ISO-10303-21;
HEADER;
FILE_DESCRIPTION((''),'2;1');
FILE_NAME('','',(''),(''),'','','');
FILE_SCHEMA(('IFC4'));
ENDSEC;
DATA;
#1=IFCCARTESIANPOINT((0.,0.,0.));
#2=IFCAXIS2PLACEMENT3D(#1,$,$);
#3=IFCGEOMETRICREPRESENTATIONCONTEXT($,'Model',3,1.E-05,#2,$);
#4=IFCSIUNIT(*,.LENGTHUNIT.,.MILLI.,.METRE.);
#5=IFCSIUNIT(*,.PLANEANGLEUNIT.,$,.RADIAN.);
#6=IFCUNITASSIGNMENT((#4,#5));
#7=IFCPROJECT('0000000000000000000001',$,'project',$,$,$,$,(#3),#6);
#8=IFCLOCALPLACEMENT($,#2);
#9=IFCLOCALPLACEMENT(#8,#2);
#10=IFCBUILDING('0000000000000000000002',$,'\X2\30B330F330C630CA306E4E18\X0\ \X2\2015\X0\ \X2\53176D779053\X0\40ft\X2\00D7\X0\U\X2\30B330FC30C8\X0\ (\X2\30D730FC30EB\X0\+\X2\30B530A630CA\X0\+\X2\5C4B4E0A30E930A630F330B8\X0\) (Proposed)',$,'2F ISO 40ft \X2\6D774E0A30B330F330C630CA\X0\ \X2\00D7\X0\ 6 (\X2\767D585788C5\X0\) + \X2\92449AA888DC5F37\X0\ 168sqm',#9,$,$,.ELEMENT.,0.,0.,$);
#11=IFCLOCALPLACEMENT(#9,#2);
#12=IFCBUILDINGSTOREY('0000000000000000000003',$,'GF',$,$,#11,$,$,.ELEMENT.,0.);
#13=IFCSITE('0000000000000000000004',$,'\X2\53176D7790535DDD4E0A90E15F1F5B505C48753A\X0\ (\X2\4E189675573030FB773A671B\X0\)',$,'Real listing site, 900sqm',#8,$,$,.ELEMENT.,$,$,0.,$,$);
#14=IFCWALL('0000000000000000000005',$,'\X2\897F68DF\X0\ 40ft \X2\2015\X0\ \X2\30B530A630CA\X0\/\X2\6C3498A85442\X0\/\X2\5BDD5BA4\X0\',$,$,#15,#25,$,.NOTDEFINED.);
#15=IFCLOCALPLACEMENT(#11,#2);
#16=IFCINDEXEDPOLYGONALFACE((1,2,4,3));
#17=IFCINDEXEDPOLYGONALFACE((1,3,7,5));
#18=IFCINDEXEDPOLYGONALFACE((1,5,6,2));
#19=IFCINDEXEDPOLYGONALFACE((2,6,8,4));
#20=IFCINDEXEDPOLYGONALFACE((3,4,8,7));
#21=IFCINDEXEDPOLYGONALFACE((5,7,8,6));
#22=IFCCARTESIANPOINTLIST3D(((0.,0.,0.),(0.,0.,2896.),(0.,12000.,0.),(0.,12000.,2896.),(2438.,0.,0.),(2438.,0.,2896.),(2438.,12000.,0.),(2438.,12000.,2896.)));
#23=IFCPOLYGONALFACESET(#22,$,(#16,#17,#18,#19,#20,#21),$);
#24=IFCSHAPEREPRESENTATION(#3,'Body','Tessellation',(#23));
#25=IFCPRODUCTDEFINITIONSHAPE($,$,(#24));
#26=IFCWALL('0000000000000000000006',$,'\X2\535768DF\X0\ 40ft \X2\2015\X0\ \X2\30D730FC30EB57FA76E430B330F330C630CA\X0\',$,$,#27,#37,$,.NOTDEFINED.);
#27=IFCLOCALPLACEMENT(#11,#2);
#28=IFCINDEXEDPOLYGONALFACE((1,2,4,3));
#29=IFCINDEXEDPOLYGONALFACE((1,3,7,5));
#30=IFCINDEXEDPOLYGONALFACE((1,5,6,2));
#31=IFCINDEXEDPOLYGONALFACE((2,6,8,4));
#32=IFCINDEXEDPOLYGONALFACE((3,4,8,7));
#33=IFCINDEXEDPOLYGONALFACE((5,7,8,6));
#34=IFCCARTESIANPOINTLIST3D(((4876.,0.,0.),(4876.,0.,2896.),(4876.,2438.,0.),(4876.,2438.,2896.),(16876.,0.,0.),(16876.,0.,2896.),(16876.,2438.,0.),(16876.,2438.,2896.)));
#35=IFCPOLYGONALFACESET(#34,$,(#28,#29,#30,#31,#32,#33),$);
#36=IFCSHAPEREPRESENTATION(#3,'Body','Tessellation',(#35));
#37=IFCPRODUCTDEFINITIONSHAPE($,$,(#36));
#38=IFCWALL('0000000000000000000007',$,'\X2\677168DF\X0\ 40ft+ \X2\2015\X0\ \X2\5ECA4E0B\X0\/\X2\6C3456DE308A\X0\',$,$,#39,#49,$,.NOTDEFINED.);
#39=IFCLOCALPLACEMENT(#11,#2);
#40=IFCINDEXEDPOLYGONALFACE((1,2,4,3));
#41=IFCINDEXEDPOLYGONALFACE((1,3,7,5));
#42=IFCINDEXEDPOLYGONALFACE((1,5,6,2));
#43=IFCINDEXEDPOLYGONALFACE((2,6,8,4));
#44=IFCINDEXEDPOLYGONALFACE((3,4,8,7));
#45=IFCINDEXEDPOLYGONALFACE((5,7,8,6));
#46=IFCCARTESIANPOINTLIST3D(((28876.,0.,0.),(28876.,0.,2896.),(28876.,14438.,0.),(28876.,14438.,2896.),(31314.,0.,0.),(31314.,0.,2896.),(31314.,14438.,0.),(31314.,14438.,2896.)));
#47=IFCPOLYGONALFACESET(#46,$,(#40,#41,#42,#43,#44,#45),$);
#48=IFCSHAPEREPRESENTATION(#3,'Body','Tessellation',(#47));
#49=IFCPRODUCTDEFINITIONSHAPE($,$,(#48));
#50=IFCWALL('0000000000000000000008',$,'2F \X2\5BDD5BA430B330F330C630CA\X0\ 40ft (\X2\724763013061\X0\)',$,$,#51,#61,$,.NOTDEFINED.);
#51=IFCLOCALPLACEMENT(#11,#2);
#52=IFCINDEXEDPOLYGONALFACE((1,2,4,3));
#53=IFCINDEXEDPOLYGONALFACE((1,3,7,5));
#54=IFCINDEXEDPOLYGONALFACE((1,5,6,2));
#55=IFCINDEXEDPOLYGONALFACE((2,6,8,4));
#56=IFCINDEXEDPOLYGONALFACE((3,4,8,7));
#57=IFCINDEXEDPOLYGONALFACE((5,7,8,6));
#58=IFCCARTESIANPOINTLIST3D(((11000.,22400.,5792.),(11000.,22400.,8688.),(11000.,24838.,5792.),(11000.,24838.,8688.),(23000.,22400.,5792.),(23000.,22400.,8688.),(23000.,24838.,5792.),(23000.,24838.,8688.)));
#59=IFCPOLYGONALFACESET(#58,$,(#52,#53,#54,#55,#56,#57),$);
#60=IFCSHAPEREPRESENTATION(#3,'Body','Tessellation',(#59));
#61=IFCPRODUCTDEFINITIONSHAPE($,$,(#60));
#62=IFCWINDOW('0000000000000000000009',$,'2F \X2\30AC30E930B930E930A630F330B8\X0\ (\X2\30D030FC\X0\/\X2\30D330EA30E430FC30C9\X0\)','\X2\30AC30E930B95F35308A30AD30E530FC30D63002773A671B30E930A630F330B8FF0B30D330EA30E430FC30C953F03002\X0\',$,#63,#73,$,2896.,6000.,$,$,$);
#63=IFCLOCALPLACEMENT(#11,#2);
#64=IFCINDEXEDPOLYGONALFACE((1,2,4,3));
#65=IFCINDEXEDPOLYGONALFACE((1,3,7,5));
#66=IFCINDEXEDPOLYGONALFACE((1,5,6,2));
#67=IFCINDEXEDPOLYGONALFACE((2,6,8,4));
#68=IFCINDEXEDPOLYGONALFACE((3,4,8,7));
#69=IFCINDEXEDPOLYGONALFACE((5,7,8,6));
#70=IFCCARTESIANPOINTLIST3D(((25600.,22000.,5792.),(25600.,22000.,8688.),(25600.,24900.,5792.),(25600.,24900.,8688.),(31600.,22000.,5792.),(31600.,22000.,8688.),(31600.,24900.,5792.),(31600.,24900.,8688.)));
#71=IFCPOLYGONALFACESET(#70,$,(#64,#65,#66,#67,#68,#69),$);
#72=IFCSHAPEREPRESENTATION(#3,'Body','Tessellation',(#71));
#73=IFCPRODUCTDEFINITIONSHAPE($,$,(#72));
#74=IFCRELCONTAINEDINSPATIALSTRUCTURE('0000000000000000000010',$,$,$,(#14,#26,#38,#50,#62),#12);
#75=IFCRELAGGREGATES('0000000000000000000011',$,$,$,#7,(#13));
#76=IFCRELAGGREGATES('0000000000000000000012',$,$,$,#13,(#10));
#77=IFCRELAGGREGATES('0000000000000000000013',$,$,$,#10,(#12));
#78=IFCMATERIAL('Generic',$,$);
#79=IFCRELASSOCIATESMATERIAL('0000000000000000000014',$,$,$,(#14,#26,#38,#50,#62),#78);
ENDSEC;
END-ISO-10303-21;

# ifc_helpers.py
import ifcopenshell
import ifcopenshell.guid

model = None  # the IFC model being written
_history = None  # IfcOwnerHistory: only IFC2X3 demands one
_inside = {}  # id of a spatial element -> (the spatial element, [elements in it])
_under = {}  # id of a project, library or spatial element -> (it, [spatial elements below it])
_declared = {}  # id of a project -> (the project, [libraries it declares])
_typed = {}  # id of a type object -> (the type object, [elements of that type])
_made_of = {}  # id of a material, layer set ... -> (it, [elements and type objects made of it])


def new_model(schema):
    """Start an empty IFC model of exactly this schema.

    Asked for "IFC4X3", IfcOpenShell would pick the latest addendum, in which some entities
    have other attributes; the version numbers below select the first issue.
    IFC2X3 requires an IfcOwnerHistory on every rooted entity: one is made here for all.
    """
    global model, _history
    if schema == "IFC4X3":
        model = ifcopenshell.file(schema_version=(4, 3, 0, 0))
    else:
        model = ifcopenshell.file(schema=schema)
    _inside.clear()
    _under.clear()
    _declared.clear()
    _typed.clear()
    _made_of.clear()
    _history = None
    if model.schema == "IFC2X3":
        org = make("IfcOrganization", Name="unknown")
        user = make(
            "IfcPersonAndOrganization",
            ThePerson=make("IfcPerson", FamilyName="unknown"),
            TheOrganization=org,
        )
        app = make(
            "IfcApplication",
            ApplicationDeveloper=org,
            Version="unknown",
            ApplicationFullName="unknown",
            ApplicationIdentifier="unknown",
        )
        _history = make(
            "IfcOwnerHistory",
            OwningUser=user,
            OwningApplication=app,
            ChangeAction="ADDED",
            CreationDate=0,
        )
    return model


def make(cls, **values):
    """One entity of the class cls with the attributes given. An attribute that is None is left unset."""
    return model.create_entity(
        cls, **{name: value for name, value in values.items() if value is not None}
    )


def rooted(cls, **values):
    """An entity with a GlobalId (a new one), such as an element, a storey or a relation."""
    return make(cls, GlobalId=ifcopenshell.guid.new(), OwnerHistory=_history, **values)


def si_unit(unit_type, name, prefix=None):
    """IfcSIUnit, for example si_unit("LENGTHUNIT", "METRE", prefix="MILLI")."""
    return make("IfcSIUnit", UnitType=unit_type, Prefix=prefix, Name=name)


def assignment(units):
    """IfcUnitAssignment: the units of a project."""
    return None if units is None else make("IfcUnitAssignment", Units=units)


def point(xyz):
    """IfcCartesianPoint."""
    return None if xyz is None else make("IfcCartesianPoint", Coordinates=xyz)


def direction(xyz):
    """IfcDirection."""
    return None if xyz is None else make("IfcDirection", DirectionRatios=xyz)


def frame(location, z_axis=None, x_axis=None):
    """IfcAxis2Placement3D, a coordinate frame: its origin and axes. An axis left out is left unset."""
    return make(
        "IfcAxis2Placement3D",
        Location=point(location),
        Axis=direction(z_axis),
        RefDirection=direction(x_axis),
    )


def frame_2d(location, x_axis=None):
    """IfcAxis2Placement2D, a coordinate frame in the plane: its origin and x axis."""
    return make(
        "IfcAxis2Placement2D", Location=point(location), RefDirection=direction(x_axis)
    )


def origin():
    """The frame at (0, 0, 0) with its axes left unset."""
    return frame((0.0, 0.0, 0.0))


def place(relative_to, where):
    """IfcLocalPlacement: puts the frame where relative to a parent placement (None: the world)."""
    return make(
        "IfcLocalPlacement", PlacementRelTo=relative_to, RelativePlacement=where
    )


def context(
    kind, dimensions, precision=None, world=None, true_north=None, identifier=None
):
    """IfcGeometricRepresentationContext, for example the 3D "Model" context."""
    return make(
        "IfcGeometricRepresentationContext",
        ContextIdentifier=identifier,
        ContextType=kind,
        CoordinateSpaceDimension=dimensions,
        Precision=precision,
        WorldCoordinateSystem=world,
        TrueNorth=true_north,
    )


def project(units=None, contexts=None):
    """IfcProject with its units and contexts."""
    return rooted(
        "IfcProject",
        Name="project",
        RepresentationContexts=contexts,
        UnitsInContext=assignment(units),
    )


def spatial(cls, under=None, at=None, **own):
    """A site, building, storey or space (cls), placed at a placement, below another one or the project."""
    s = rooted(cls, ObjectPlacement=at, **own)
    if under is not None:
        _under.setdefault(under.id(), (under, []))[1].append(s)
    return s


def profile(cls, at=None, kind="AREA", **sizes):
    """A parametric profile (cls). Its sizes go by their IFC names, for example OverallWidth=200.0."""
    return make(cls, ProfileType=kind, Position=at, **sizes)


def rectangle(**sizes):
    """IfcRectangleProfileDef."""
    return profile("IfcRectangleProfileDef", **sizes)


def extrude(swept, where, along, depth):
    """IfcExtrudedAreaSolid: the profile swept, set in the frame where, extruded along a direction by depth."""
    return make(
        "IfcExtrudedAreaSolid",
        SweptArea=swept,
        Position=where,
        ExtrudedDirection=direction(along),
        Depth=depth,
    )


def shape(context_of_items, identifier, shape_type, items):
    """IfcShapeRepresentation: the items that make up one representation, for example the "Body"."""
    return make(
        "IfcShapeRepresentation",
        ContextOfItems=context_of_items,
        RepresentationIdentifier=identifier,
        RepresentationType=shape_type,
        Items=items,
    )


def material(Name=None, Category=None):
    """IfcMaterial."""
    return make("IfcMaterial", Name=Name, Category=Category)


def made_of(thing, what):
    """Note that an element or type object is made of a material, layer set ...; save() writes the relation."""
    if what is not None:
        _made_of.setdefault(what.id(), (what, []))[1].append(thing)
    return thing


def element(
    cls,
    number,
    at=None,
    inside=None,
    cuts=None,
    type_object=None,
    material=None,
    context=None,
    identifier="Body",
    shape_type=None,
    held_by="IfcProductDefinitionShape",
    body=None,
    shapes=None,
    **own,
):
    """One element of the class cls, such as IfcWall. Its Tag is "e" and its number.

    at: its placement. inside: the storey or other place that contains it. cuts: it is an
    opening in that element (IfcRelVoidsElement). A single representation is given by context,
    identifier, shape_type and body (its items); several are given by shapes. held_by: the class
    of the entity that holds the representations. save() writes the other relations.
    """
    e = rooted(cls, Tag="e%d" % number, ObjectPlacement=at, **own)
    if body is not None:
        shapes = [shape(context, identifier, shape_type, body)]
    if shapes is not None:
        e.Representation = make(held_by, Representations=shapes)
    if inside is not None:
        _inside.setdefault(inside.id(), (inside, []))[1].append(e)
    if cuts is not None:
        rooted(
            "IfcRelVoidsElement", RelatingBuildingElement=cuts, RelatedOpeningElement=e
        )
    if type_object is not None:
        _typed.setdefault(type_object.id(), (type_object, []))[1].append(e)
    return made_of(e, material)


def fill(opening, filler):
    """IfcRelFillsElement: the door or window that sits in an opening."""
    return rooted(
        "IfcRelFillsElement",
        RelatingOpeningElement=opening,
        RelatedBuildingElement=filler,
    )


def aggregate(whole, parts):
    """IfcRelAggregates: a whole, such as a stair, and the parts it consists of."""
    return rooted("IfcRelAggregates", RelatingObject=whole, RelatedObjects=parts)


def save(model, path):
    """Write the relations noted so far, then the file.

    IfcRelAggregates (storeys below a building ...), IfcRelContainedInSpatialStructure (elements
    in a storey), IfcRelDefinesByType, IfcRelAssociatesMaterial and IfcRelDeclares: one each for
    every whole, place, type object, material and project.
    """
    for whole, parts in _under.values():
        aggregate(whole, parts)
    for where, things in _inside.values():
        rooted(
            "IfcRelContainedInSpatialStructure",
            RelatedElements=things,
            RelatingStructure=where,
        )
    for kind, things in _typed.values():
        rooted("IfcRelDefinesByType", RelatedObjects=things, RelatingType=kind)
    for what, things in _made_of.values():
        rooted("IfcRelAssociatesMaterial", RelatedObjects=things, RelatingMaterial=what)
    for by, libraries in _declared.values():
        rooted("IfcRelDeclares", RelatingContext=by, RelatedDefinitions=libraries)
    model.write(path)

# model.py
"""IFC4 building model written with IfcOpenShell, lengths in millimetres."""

from ifc_helpers import new_model, si_unit, frame, frame_2d, origin, place, context, project, spatial, rectangle, extrude, material, element, fill, save


model = new_model("IFC4")

# Units and contexts
model_context = context("Model", 3, precision=1e-05, world=origin())
ifc_project = project(units=[si_unit("LENGTHUNIT", "METRE", prefix="MILLI"), si_unit("PLANEANGLEUNIT", "RADIAN")], contexts=[model_context])

# Site, building, storey
site_placement = place(None, origin())
site = spatial("IfcSite", under=ifc_project, at=site_placement, Name="北海道川上郡弟子屈町 (丘陵地・眺望)", ObjectType="Real listing site, 900sqm", CompositionType="ELEMENT", RefElevation=0.0)
building_placement = place(site_placement, origin())
building = spatial("IfcBuilding", under=site, at=building_placement, Name="コンテナの丘 ― 北海道40ft×Uコート (プール+サウナ+屋上ラウンジ) (Proposed)", ObjectType="2F ISO 40ft 海上コンテナ × 6 (白塗装) + 鉄骨補強 168sqm", CompositionType="ELEMENT", ElevationOfRefHeight=0.0, ElevationOfTerrain=0.0)
storey_placement = place(building_placement, origin())
storey = spatial("IfcBuildingStorey", under=building, at=storey_placement, Name="GF", CompositionType="ELEMENT", Elevation=0.0)

# Shared definitions
ifc_material = material(Name="Generic")

# Walls
wall_1_placement = place(storey_placement, origin())
element("IfcWall", 1, at=wall_1_placement, inside=storey, material=ifc_material, Name="西棟 40ft ― サウナ/水風呂/寝室", PredefinedType="NOTDEFINED", context=model_context, shape_type="SweptSolid", body=[
    extrude(rectangle(XDim=2438.0, YDim=12000.0, at=frame_2d((1219.0, 6000.0))), origin(), (0.0, 0.0, 1.0), 2896.0),
])
wall_2_placement = place(storey_placement, frame((2438.0, 0.0, 0.0)))
element("IfcWall", 2, at=wall_2_placement, inside=storey, material=ifc_material, Name="南棟 40ft ― プール基盤コンテナ", PredefinedType="NOTDEFINED", context=model_context, shape_type="SweptSolid", body=[
    extrude(rectangle(XDim=12000.0, YDim=2438.0, at=frame_2d((6000.0, 1219.0))), frame((2438.0, 0.0, 0.0)), (0.0, 0.0, 1.0), 2896.0),
])
wall_3_placement = place(storey_placement, frame((14438.0, 0.0, 0.0)))
element("IfcWall", 3, at=wall_3_placement, inside=storey, material=ifc_material, Name="東棟 40ft+ ― 廊下/水回り", PredefinedType="NOTDEFINED", context=model_context, shape_type="SweptSolid", body=[
    extrude(rectangle(XDim=2438.0, YDim=14438.0, at=frame_2d((1219.0, 7219.0))), frame((14438.0, 0.0, 0.0)), (0.0, 0.0, 1.0), 2896.0),
])

# Wall, opening, window
wall_4_placement = place(storey_placement, frame((5500.0, 11200.0, 2896.0)))
wall_4 = element("IfcWall", 4, at=wall_4_placement, inside=storey, material=ifc_material, Name="2F 寝室コンテナ 40ft (片持ち)", PredefinedType="NOTDEFINED", context=model_context, shape_type="SweptSolid", body=[
    extrude(rectangle(XDim=12000.0, YDim=2438.0, at=frame_2d((6000.0, 1219.0))), frame((5500.0, 11200.0, 2896.0)), (0.0, 0.0, 1.0), 2896.0),
])
opening_1_placement = place(storey_placement, frame((12800.0, 11000.0, 2896.0)))
opening_1 = element("IfcOpeningElement", 5, at=opening_1_placement, cuts=wall_4, PredefinedType="NOTDEFINED", context=model_context, shape_type="SweptSolid", body=[
    extrude(rectangle(XDim=6000.0, YDim=2900.0, at=frame_2d((3000.0, 1450.0))), frame((12800.0, 11000.0, 2896.0)), (0.0, 0.0, 1.0), 2896.0),
])
window_1_placement = place(storey_placement, frame((12800.0, 11000.0, 2896.0)))
window_1 = element("IfcWindow", 6, at=window_1_placement, inside=storey, material=ifc_material, Name="2F ガラスラウンジ (バー/ビリヤード)", Description="ガラス張りキューブ。眺望ラウンジ＋ビリヤード台。", OverallHeight=2896.0, OverallWidth=6000.0, context=model_context, shape_type="SweptSolid", body=[
    extrude(rectangle(XDim=6000.0, YDim=2900.0, at=frame_2d((3000.0, 1450.0))), frame((12800.0, 11000.0, 2896.0)), (0.0, 0.0, 1.0), 2896.0),
])
fill(opening_1, window_1)

save(model, "model.ifc")
